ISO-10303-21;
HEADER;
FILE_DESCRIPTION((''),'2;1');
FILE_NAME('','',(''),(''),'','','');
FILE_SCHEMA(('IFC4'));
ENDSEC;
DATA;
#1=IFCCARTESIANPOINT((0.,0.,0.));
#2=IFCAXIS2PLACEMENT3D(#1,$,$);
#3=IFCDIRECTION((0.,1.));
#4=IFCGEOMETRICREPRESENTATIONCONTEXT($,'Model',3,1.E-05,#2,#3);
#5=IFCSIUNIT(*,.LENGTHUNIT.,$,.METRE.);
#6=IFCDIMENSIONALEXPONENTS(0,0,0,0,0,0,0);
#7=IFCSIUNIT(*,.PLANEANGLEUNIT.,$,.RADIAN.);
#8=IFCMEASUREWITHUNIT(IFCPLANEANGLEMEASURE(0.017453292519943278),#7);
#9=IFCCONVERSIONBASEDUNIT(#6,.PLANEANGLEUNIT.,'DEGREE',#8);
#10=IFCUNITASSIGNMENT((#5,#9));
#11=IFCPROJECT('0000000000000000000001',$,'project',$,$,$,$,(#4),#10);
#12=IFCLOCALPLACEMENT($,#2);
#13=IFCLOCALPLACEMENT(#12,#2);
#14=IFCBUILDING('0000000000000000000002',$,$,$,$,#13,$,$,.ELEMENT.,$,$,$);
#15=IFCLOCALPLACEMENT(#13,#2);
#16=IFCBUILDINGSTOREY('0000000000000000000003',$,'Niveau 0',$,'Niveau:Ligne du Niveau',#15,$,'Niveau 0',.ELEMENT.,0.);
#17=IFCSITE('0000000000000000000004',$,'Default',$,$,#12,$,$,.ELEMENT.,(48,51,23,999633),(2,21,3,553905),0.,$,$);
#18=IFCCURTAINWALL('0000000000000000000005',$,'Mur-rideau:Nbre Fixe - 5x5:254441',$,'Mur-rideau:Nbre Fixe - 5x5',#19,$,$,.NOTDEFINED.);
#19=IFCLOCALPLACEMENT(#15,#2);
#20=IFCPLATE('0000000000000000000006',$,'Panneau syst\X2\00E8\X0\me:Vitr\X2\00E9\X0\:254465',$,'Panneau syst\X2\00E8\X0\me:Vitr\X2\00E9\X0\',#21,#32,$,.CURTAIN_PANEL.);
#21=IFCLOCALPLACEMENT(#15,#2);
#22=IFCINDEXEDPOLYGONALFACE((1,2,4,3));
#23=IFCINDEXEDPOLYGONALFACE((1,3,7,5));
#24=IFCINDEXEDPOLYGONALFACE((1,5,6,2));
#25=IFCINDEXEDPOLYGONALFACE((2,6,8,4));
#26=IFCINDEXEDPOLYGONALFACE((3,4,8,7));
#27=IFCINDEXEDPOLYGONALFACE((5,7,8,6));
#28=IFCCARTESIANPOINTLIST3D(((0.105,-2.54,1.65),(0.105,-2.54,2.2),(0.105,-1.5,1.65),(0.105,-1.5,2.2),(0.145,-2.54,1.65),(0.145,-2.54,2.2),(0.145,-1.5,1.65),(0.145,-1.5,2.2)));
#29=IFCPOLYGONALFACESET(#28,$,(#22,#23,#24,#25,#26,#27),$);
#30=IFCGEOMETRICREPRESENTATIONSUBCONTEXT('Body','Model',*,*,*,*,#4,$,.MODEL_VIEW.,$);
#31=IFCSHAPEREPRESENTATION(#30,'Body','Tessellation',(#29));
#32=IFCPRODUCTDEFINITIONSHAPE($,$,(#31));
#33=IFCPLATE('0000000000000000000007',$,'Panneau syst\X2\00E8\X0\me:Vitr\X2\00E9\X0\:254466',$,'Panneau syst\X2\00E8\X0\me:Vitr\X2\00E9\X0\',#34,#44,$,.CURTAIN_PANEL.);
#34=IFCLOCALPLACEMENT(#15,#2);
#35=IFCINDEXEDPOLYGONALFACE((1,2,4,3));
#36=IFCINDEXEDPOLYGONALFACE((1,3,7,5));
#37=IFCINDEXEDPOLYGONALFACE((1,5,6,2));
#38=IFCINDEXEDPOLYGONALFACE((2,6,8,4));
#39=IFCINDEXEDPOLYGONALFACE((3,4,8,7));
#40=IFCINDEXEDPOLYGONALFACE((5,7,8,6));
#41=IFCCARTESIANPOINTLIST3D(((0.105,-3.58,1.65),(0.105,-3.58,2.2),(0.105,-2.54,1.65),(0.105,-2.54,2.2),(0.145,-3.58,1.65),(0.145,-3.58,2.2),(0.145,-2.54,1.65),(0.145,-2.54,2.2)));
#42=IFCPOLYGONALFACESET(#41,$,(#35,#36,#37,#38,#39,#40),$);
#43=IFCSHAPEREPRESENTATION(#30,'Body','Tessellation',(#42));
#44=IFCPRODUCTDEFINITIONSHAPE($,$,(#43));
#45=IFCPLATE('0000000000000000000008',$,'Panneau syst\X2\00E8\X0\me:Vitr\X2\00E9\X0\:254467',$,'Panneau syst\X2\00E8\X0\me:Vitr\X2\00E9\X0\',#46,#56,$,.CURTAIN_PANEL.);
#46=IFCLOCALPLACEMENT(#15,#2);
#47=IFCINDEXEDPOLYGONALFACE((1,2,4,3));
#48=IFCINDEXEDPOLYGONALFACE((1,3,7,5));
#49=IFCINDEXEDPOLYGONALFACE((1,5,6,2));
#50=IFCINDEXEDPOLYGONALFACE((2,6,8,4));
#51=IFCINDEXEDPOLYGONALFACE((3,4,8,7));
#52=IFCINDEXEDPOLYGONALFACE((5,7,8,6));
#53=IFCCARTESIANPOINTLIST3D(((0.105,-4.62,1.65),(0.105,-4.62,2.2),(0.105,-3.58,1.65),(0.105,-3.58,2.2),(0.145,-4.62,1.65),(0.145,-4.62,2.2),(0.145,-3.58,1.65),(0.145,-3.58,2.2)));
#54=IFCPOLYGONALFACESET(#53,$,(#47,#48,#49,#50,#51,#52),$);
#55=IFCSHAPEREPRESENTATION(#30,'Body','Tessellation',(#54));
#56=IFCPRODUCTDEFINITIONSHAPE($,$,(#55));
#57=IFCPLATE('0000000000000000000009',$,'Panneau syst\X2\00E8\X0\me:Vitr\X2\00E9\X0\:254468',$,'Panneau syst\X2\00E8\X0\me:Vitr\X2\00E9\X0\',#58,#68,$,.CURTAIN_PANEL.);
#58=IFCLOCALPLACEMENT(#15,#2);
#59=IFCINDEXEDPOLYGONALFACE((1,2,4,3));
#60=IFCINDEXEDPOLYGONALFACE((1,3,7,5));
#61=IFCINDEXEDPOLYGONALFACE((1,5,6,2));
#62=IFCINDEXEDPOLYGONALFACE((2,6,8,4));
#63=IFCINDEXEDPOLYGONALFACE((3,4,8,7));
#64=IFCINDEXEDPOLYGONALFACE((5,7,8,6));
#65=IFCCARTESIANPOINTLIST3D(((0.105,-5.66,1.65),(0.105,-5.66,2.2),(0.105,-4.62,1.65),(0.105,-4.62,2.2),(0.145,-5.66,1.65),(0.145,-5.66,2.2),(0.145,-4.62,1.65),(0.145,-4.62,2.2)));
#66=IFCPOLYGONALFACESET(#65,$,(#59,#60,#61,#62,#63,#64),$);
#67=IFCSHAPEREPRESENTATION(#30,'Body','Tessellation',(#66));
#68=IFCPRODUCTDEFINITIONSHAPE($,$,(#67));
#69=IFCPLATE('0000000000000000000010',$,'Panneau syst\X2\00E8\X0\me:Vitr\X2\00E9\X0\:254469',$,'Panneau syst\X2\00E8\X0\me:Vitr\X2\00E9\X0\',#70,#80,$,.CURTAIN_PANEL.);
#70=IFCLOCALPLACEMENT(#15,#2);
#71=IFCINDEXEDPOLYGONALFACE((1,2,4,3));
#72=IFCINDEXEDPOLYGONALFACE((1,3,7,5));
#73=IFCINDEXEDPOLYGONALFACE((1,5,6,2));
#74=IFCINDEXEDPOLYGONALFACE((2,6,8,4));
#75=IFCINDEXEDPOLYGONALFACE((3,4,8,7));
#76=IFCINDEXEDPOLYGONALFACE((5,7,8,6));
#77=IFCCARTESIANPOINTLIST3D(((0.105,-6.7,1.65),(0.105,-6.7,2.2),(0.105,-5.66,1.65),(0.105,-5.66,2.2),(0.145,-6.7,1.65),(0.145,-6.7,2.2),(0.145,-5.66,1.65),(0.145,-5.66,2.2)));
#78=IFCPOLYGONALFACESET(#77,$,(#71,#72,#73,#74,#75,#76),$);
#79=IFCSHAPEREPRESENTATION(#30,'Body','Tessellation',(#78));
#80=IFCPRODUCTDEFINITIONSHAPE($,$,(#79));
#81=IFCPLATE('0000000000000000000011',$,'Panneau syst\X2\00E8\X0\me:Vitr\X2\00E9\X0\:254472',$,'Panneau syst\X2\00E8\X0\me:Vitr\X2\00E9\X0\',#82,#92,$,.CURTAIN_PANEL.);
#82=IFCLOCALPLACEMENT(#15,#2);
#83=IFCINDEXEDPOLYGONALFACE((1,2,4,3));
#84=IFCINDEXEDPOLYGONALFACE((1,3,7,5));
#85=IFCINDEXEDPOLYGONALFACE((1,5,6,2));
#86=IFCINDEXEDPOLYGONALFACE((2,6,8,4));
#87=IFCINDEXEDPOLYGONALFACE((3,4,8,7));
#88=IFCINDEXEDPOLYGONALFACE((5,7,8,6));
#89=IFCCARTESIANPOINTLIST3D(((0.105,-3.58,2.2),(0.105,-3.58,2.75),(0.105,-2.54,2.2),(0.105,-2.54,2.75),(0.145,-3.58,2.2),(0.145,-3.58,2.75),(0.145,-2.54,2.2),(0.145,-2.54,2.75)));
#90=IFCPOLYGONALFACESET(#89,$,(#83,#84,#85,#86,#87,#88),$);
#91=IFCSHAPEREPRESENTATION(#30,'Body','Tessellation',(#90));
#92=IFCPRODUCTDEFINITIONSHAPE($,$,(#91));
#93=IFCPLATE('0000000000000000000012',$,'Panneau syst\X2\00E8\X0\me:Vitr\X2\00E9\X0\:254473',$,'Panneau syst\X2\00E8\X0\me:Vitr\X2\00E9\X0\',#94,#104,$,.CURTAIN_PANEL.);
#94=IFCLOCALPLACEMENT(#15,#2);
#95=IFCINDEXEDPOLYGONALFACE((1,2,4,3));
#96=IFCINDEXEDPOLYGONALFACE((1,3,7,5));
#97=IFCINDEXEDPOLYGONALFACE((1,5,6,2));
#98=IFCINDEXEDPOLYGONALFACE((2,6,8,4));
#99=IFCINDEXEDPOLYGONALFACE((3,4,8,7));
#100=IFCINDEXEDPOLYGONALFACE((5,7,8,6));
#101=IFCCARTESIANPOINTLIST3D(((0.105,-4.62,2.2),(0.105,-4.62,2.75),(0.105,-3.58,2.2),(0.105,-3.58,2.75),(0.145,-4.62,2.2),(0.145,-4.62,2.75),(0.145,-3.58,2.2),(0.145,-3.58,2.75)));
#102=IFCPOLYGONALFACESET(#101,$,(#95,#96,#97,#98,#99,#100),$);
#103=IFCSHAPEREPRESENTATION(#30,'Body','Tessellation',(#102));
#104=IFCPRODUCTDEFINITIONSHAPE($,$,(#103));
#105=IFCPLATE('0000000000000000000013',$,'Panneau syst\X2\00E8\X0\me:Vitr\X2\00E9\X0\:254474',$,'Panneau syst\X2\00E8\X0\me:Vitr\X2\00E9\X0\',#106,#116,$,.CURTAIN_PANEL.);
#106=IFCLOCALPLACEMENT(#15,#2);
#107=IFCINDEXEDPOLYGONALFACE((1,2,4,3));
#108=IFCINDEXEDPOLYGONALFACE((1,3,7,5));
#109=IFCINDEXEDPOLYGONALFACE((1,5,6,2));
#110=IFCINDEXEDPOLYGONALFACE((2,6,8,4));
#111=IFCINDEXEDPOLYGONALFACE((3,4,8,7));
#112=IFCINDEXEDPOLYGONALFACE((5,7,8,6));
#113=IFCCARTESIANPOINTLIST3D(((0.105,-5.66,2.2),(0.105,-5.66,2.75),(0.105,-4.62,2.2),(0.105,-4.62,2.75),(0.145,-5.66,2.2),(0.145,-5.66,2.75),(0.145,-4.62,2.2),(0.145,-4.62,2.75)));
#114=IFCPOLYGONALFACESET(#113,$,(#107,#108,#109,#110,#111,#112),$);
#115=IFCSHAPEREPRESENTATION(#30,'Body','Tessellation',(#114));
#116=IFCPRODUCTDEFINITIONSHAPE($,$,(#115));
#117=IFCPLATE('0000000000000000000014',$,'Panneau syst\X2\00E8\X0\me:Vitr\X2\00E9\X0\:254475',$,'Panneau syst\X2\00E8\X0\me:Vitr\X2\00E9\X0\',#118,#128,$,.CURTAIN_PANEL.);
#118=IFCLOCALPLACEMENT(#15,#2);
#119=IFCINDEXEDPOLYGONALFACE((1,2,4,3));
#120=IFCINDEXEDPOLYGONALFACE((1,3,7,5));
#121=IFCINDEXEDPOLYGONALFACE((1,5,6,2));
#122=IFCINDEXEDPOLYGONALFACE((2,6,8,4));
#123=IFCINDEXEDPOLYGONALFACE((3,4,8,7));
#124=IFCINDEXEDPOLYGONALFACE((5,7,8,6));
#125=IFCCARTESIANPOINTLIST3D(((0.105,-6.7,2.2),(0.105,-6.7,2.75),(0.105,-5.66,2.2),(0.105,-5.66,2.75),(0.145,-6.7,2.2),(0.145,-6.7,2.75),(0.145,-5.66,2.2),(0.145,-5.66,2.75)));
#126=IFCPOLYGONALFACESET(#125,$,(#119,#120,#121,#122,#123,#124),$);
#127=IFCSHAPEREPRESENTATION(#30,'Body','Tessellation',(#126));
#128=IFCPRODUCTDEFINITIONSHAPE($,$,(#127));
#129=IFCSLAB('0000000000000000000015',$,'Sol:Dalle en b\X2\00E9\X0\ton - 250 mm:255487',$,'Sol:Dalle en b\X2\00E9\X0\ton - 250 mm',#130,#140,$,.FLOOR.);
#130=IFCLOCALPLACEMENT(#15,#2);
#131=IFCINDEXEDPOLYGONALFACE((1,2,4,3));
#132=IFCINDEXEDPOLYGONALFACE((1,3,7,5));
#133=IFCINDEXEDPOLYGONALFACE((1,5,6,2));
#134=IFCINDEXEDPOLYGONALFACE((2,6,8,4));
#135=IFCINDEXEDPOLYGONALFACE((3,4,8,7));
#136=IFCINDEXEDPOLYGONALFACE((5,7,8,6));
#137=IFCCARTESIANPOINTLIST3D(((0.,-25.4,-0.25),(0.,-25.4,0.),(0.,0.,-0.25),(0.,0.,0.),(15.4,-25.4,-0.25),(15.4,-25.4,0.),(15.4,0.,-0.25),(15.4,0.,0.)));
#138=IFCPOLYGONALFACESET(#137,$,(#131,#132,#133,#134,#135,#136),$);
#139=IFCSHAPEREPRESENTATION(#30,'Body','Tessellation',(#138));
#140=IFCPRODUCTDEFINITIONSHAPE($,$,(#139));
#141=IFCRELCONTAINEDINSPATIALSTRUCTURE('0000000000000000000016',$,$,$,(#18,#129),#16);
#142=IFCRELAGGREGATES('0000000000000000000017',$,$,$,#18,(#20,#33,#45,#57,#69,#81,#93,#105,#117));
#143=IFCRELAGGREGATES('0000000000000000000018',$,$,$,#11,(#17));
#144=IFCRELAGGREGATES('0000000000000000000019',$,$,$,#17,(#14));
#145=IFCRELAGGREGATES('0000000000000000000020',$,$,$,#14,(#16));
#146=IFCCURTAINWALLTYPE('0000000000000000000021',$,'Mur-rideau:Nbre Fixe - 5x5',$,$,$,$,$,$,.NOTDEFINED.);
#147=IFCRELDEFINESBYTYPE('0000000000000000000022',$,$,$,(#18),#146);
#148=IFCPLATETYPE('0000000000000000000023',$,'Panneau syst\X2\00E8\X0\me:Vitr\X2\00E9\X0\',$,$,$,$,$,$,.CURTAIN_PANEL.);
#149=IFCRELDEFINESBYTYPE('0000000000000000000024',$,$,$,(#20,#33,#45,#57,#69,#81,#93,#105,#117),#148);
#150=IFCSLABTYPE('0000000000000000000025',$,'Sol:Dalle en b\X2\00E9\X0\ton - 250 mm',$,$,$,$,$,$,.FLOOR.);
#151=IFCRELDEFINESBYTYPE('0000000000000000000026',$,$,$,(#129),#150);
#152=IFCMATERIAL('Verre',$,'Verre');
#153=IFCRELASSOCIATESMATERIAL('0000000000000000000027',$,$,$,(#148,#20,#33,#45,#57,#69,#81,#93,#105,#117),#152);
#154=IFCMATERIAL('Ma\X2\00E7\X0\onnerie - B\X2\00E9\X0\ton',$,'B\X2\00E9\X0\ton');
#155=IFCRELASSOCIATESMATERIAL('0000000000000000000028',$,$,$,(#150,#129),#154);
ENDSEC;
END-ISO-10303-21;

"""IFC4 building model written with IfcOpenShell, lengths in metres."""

from ifc_helpers import new_model, entity, si_unit, converted_unit, direction, frame, origin, place, context, subcontext, project, spatial, indexed_curve, outline, extrude, source, transform, mapped, material, type_object, type_shapes, element, aggregate, save


model = new_model("IFC4")

# Units and contexts
model_context = context("Model", 3, precision=1e-05, world=origin(), true_north=direction((0.0, 1.0)))
body_context = subcontext(model_context, "Body", "Model", "MODEL_VIEW")
ifc_project = project(units=[si_unit("LENGTHUNIT", "METRE"), converted_unit("PLANEANGLEUNIT", "DEGREE", entity("IfcPlaneAngleMeasure", 0.017453292519943278), si_unit("PLANEANGLEUNIT", "RADIAN"), dimensions=[0, 0, 0, 0, 0, 0, 0])], contexts=[model_context])

# Site, building, storey
site_placement = place(None, origin())
site = spatial("IfcSite", under=ifc_project, at=site_placement, Name="Default", CompositionType="ELEMENT", RefLatitude=(48, 51, 23, 999633), RefLongitude=(2, 21, 3, 553905), RefElevation=0.0)
building_placement = place(site_placement, origin())
building = spatial("IfcBuilding", under=site, at=building_placement, CompositionType="ELEMENT")
storey_placement = place(building_placement, origin())
storey = spatial("IfcBuildingStorey", under=building, at=storey_placement, Name="Niveau 0", ObjectType="Niveau:Ligne du Niveau", LongName="Niveau 0", CompositionType="ELEMENT", Elevation=0.0)

# Curtain wall, plates
curtain_wall_type = type_object("IfcCurtainWallType", Name="Mur-rideau:Nbre Fixe - 5x5", PredefinedType="NOTDEFINED")
curtain_wall_placement = place(storey_placement, origin())
curtain_wall = element("IfcCurtainWall", 1, at=curtain_wall_placement, inside=storey, type_object=curtain_wall_type, Name="Mur-rideau:Nbre Fixe - 5x5:254441", ObjectType="Mur-rideau:Nbre Fixe - 5x5", PredefinedType="NOTDEFINED")
ifc_material_1 = material(Name="Verre", Category="Verre")
plate_type = type_object("IfcPlateType", Name="Panneau système:Vitré", PredefinedType="CURTAIN_PANEL", material=ifc_material_1)
shared_shape = source(origin(), body_context, "Body", "SweptSolid", [
    extrude(outline(indexed_curve([(-0.02, -0.52), (0.02, -0.52), (0.02, 0.52), (-0.02, 0.52), (-0.02, -0.52)], self_intersect=False)), frame((0.52, 0.02, 0.0), z_axis=(0.0, 0.0, 1.0), x_axis=(0.0, 1.0, 0.0)), (0.0, 0.0, 1.0), 0.55),
])
type_shapes(plate_type, [shared_shape])
plate_1_placement = place(curtain_wall_placement, frame((0.105, -1.5, 1.65), z_axis=(0.0, 0.0, 1.0), x_axis=(0.0, -1.0, 0.0)))
plate_1 = element("IfcPlate", 2, at=plate_1_placement, type_object=plate_type, material=ifc_material_1, Name="Panneau système:Vitré:254465", ObjectType="Panneau système:Vitré", PredefinedType="CURTAIN_PANEL", context=body_context, shape_type="MappedRepresentation", body=[
    mapped(shared_shape, transform((0.0, 0.0, 0.0), scale=1.0)),
])
plate_2_placement = place(curtain_wall_placement, frame((0.105, -2.54, 1.65), z_axis=(0.0, 0.0, 1.0), x_axis=(0.0, -1.0, 0.0)))
plate_2 = element("IfcPlate", 3, at=plate_2_placement, type_object=plate_type, material=ifc_material_1, Name="Panneau système:Vitré:254466", ObjectType="Panneau système:Vitré", PredefinedType="CURTAIN_PANEL", context=body_context, shape_type="MappedRepresentation", body=[
    mapped(shared_shape, transform((0.0, 0.0, 0.0), scale=1.0)),
])
plate_3_placement = place(curtain_wall_placement, frame((0.105, -3.58, 1.65), z_axis=(0.0, 0.0, 1.0), x_axis=(0.0, -1.0, 0.0)))
plate_3 = element("IfcPlate", 4, at=plate_3_placement, type_object=plate_type, material=ifc_material_1, Name="Panneau système:Vitré:254467", ObjectType="Panneau système:Vitré", PredefinedType="CURTAIN_PANEL", context=body_context, shape_type="MappedRepresentation", body=[
    mapped(shared_shape, transform((0.0, 0.0, 0.0), scale=1.0)),
])
plate_4_placement = place(curtain_wall_placement, frame((0.105, -4.62, 1.65), z_axis=(0.0, 0.0, 1.0), x_axis=(0.0, -1.0, 0.0)))
plate_4 = element("IfcPlate", 5, at=plate_4_placement, type_object=plate_type, material=ifc_material_1, Name="Panneau système:Vitré:254468", ObjectType="Panneau système:Vitré", PredefinedType="CURTAIN_PANEL", context=body_context, shape_type="MappedRepresentation", body=[
    mapped(shared_shape, transform((0.0, 0.0, 0.0), scale=1.0)),
])
plate_5_placement = place(curtain_wall_placement, frame((0.105, -5.66, 1.65), z_axis=(0.0, 0.0, 1.0), x_axis=(0.0, -1.0, 0.0)))
plate_5 = element("IfcPlate", 6, at=plate_5_placement, type_object=plate_type, material=ifc_material_1, Name="Panneau système:Vitré:254469", ObjectType="Panneau système:Vitré", PredefinedType="CURTAIN_PANEL", context=body_context, shape_type="MappedRepresentation", body=[
    mapped(shared_shape, transform((0.0, 0.0, 0.0), scale=1.0)),
])
plate_6_placement = place(curtain_wall_placement, frame((0.105, -2.54, 2.2), z_axis=(0.0, 0.0, 1.0), x_axis=(0.0, -1.0, 0.0)))
plate_6 = element("IfcPlate", 7, at=plate_6_placement, type_object=plate_type, material=ifc_material_1, Name="Panneau système:Vitré:254472", ObjectType="Panneau système:Vitré", PredefinedType="CURTAIN_PANEL", context=body_context, shape_type="MappedRepresentation", body=[
    mapped(shared_shape, transform((0.0, 0.0, 0.0), scale=1.0)),
])
plate_7_placement = place(curtain_wall_placement, frame((0.105, -3.58, 2.2), z_axis=(0.0, 0.0, 1.0), x_axis=(0.0, -1.0, 0.0)))
plate_7 = element("IfcPlate", 8, at=plate_7_placement, type_object=plate_type, material=ifc_material_1, Name="Panneau système:Vitré:254473", ObjectType="Panneau système:Vitré", PredefinedType="CURTAIN_PANEL", context=body_context, shape_type="MappedRepresentation", body=[
    mapped(shared_shape, transform((0.0, 0.0, 0.0), scale=1.0)),
])
plate_8_placement = place(curtain_wall_placement, frame((0.105, -4.62, 2.2), z_axis=(0.0, 0.0, 1.0), x_axis=(0.0, -1.0, 0.0)))
plate_8 = element("IfcPlate", 9, at=plate_8_placement, type_object=plate_type, material=ifc_material_1, Name="Panneau système:Vitré:254474", ObjectType="Panneau système:Vitré", PredefinedType="CURTAIN_PANEL", context=body_context, shape_type="MappedRepresentation", body=[
    mapped(shared_shape, transform((0.0, 0.0, 0.0), scale=1.0)),
])
plate_9_placement = place(curtain_wall_placement, frame((0.105, -5.66, 2.2), z_axis=(0.0, 0.0, 1.0), x_axis=(0.0, -1.0, 0.0)))
plate_9 = element("IfcPlate", 10, at=plate_9_placement, type_object=plate_type, material=ifc_material_1, Name="Panneau système:Vitré:254475", ObjectType="Panneau système:Vitré", PredefinedType="CURTAIN_PANEL", context=body_context, shape_type="MappedRepresentation", body=[
    mapped(shared_shape, transform((0.0, 0.0, 0.0), scale=1.0)),
])
aggregate(curtain_wall, [plate_1, plate_2, plate_3, plate_4, plate_5, plate_6, plate_7, plate_8, plate_9])

# Slab
ifc_material_2 = material(Name="Maçonnerie - Béton", Category="Béton")
slab_type = type_object("IfcSlabType", Name="Sol:Dalle en béton - 250 mm", PredefinedType="FLOOR", material=ifc_material_2)
slab_placement = place(storey_placement, origin())
element("IfcSlab", 11, at=slab_placement, inside=storey, type_object=slab_type, material=ifc_material_2, Name="Sol:Dalle en béton - 250 mm:255487", ObjectType="Sol:Dalle en béton - 250 mm", PredefinedType="FLOOR", context=body_context, shape_type="SweptSolid", body=[
    extrude(outline(indexed_curve([(-12.7, -7.7), (12.7, -7.7), (12.7, 7.7), (-12.7, 7.7), (-12.7, -7.7)], self_intersect=False)), frame((7.7, -12.7, 0.0), z_axis=(0.0, 0.0, -1.0), x_axis=(0.0, 1.0, 0.0)), (0.0, 0.0, 1.0), 0.25),
])

save(model, "model.ifc")
